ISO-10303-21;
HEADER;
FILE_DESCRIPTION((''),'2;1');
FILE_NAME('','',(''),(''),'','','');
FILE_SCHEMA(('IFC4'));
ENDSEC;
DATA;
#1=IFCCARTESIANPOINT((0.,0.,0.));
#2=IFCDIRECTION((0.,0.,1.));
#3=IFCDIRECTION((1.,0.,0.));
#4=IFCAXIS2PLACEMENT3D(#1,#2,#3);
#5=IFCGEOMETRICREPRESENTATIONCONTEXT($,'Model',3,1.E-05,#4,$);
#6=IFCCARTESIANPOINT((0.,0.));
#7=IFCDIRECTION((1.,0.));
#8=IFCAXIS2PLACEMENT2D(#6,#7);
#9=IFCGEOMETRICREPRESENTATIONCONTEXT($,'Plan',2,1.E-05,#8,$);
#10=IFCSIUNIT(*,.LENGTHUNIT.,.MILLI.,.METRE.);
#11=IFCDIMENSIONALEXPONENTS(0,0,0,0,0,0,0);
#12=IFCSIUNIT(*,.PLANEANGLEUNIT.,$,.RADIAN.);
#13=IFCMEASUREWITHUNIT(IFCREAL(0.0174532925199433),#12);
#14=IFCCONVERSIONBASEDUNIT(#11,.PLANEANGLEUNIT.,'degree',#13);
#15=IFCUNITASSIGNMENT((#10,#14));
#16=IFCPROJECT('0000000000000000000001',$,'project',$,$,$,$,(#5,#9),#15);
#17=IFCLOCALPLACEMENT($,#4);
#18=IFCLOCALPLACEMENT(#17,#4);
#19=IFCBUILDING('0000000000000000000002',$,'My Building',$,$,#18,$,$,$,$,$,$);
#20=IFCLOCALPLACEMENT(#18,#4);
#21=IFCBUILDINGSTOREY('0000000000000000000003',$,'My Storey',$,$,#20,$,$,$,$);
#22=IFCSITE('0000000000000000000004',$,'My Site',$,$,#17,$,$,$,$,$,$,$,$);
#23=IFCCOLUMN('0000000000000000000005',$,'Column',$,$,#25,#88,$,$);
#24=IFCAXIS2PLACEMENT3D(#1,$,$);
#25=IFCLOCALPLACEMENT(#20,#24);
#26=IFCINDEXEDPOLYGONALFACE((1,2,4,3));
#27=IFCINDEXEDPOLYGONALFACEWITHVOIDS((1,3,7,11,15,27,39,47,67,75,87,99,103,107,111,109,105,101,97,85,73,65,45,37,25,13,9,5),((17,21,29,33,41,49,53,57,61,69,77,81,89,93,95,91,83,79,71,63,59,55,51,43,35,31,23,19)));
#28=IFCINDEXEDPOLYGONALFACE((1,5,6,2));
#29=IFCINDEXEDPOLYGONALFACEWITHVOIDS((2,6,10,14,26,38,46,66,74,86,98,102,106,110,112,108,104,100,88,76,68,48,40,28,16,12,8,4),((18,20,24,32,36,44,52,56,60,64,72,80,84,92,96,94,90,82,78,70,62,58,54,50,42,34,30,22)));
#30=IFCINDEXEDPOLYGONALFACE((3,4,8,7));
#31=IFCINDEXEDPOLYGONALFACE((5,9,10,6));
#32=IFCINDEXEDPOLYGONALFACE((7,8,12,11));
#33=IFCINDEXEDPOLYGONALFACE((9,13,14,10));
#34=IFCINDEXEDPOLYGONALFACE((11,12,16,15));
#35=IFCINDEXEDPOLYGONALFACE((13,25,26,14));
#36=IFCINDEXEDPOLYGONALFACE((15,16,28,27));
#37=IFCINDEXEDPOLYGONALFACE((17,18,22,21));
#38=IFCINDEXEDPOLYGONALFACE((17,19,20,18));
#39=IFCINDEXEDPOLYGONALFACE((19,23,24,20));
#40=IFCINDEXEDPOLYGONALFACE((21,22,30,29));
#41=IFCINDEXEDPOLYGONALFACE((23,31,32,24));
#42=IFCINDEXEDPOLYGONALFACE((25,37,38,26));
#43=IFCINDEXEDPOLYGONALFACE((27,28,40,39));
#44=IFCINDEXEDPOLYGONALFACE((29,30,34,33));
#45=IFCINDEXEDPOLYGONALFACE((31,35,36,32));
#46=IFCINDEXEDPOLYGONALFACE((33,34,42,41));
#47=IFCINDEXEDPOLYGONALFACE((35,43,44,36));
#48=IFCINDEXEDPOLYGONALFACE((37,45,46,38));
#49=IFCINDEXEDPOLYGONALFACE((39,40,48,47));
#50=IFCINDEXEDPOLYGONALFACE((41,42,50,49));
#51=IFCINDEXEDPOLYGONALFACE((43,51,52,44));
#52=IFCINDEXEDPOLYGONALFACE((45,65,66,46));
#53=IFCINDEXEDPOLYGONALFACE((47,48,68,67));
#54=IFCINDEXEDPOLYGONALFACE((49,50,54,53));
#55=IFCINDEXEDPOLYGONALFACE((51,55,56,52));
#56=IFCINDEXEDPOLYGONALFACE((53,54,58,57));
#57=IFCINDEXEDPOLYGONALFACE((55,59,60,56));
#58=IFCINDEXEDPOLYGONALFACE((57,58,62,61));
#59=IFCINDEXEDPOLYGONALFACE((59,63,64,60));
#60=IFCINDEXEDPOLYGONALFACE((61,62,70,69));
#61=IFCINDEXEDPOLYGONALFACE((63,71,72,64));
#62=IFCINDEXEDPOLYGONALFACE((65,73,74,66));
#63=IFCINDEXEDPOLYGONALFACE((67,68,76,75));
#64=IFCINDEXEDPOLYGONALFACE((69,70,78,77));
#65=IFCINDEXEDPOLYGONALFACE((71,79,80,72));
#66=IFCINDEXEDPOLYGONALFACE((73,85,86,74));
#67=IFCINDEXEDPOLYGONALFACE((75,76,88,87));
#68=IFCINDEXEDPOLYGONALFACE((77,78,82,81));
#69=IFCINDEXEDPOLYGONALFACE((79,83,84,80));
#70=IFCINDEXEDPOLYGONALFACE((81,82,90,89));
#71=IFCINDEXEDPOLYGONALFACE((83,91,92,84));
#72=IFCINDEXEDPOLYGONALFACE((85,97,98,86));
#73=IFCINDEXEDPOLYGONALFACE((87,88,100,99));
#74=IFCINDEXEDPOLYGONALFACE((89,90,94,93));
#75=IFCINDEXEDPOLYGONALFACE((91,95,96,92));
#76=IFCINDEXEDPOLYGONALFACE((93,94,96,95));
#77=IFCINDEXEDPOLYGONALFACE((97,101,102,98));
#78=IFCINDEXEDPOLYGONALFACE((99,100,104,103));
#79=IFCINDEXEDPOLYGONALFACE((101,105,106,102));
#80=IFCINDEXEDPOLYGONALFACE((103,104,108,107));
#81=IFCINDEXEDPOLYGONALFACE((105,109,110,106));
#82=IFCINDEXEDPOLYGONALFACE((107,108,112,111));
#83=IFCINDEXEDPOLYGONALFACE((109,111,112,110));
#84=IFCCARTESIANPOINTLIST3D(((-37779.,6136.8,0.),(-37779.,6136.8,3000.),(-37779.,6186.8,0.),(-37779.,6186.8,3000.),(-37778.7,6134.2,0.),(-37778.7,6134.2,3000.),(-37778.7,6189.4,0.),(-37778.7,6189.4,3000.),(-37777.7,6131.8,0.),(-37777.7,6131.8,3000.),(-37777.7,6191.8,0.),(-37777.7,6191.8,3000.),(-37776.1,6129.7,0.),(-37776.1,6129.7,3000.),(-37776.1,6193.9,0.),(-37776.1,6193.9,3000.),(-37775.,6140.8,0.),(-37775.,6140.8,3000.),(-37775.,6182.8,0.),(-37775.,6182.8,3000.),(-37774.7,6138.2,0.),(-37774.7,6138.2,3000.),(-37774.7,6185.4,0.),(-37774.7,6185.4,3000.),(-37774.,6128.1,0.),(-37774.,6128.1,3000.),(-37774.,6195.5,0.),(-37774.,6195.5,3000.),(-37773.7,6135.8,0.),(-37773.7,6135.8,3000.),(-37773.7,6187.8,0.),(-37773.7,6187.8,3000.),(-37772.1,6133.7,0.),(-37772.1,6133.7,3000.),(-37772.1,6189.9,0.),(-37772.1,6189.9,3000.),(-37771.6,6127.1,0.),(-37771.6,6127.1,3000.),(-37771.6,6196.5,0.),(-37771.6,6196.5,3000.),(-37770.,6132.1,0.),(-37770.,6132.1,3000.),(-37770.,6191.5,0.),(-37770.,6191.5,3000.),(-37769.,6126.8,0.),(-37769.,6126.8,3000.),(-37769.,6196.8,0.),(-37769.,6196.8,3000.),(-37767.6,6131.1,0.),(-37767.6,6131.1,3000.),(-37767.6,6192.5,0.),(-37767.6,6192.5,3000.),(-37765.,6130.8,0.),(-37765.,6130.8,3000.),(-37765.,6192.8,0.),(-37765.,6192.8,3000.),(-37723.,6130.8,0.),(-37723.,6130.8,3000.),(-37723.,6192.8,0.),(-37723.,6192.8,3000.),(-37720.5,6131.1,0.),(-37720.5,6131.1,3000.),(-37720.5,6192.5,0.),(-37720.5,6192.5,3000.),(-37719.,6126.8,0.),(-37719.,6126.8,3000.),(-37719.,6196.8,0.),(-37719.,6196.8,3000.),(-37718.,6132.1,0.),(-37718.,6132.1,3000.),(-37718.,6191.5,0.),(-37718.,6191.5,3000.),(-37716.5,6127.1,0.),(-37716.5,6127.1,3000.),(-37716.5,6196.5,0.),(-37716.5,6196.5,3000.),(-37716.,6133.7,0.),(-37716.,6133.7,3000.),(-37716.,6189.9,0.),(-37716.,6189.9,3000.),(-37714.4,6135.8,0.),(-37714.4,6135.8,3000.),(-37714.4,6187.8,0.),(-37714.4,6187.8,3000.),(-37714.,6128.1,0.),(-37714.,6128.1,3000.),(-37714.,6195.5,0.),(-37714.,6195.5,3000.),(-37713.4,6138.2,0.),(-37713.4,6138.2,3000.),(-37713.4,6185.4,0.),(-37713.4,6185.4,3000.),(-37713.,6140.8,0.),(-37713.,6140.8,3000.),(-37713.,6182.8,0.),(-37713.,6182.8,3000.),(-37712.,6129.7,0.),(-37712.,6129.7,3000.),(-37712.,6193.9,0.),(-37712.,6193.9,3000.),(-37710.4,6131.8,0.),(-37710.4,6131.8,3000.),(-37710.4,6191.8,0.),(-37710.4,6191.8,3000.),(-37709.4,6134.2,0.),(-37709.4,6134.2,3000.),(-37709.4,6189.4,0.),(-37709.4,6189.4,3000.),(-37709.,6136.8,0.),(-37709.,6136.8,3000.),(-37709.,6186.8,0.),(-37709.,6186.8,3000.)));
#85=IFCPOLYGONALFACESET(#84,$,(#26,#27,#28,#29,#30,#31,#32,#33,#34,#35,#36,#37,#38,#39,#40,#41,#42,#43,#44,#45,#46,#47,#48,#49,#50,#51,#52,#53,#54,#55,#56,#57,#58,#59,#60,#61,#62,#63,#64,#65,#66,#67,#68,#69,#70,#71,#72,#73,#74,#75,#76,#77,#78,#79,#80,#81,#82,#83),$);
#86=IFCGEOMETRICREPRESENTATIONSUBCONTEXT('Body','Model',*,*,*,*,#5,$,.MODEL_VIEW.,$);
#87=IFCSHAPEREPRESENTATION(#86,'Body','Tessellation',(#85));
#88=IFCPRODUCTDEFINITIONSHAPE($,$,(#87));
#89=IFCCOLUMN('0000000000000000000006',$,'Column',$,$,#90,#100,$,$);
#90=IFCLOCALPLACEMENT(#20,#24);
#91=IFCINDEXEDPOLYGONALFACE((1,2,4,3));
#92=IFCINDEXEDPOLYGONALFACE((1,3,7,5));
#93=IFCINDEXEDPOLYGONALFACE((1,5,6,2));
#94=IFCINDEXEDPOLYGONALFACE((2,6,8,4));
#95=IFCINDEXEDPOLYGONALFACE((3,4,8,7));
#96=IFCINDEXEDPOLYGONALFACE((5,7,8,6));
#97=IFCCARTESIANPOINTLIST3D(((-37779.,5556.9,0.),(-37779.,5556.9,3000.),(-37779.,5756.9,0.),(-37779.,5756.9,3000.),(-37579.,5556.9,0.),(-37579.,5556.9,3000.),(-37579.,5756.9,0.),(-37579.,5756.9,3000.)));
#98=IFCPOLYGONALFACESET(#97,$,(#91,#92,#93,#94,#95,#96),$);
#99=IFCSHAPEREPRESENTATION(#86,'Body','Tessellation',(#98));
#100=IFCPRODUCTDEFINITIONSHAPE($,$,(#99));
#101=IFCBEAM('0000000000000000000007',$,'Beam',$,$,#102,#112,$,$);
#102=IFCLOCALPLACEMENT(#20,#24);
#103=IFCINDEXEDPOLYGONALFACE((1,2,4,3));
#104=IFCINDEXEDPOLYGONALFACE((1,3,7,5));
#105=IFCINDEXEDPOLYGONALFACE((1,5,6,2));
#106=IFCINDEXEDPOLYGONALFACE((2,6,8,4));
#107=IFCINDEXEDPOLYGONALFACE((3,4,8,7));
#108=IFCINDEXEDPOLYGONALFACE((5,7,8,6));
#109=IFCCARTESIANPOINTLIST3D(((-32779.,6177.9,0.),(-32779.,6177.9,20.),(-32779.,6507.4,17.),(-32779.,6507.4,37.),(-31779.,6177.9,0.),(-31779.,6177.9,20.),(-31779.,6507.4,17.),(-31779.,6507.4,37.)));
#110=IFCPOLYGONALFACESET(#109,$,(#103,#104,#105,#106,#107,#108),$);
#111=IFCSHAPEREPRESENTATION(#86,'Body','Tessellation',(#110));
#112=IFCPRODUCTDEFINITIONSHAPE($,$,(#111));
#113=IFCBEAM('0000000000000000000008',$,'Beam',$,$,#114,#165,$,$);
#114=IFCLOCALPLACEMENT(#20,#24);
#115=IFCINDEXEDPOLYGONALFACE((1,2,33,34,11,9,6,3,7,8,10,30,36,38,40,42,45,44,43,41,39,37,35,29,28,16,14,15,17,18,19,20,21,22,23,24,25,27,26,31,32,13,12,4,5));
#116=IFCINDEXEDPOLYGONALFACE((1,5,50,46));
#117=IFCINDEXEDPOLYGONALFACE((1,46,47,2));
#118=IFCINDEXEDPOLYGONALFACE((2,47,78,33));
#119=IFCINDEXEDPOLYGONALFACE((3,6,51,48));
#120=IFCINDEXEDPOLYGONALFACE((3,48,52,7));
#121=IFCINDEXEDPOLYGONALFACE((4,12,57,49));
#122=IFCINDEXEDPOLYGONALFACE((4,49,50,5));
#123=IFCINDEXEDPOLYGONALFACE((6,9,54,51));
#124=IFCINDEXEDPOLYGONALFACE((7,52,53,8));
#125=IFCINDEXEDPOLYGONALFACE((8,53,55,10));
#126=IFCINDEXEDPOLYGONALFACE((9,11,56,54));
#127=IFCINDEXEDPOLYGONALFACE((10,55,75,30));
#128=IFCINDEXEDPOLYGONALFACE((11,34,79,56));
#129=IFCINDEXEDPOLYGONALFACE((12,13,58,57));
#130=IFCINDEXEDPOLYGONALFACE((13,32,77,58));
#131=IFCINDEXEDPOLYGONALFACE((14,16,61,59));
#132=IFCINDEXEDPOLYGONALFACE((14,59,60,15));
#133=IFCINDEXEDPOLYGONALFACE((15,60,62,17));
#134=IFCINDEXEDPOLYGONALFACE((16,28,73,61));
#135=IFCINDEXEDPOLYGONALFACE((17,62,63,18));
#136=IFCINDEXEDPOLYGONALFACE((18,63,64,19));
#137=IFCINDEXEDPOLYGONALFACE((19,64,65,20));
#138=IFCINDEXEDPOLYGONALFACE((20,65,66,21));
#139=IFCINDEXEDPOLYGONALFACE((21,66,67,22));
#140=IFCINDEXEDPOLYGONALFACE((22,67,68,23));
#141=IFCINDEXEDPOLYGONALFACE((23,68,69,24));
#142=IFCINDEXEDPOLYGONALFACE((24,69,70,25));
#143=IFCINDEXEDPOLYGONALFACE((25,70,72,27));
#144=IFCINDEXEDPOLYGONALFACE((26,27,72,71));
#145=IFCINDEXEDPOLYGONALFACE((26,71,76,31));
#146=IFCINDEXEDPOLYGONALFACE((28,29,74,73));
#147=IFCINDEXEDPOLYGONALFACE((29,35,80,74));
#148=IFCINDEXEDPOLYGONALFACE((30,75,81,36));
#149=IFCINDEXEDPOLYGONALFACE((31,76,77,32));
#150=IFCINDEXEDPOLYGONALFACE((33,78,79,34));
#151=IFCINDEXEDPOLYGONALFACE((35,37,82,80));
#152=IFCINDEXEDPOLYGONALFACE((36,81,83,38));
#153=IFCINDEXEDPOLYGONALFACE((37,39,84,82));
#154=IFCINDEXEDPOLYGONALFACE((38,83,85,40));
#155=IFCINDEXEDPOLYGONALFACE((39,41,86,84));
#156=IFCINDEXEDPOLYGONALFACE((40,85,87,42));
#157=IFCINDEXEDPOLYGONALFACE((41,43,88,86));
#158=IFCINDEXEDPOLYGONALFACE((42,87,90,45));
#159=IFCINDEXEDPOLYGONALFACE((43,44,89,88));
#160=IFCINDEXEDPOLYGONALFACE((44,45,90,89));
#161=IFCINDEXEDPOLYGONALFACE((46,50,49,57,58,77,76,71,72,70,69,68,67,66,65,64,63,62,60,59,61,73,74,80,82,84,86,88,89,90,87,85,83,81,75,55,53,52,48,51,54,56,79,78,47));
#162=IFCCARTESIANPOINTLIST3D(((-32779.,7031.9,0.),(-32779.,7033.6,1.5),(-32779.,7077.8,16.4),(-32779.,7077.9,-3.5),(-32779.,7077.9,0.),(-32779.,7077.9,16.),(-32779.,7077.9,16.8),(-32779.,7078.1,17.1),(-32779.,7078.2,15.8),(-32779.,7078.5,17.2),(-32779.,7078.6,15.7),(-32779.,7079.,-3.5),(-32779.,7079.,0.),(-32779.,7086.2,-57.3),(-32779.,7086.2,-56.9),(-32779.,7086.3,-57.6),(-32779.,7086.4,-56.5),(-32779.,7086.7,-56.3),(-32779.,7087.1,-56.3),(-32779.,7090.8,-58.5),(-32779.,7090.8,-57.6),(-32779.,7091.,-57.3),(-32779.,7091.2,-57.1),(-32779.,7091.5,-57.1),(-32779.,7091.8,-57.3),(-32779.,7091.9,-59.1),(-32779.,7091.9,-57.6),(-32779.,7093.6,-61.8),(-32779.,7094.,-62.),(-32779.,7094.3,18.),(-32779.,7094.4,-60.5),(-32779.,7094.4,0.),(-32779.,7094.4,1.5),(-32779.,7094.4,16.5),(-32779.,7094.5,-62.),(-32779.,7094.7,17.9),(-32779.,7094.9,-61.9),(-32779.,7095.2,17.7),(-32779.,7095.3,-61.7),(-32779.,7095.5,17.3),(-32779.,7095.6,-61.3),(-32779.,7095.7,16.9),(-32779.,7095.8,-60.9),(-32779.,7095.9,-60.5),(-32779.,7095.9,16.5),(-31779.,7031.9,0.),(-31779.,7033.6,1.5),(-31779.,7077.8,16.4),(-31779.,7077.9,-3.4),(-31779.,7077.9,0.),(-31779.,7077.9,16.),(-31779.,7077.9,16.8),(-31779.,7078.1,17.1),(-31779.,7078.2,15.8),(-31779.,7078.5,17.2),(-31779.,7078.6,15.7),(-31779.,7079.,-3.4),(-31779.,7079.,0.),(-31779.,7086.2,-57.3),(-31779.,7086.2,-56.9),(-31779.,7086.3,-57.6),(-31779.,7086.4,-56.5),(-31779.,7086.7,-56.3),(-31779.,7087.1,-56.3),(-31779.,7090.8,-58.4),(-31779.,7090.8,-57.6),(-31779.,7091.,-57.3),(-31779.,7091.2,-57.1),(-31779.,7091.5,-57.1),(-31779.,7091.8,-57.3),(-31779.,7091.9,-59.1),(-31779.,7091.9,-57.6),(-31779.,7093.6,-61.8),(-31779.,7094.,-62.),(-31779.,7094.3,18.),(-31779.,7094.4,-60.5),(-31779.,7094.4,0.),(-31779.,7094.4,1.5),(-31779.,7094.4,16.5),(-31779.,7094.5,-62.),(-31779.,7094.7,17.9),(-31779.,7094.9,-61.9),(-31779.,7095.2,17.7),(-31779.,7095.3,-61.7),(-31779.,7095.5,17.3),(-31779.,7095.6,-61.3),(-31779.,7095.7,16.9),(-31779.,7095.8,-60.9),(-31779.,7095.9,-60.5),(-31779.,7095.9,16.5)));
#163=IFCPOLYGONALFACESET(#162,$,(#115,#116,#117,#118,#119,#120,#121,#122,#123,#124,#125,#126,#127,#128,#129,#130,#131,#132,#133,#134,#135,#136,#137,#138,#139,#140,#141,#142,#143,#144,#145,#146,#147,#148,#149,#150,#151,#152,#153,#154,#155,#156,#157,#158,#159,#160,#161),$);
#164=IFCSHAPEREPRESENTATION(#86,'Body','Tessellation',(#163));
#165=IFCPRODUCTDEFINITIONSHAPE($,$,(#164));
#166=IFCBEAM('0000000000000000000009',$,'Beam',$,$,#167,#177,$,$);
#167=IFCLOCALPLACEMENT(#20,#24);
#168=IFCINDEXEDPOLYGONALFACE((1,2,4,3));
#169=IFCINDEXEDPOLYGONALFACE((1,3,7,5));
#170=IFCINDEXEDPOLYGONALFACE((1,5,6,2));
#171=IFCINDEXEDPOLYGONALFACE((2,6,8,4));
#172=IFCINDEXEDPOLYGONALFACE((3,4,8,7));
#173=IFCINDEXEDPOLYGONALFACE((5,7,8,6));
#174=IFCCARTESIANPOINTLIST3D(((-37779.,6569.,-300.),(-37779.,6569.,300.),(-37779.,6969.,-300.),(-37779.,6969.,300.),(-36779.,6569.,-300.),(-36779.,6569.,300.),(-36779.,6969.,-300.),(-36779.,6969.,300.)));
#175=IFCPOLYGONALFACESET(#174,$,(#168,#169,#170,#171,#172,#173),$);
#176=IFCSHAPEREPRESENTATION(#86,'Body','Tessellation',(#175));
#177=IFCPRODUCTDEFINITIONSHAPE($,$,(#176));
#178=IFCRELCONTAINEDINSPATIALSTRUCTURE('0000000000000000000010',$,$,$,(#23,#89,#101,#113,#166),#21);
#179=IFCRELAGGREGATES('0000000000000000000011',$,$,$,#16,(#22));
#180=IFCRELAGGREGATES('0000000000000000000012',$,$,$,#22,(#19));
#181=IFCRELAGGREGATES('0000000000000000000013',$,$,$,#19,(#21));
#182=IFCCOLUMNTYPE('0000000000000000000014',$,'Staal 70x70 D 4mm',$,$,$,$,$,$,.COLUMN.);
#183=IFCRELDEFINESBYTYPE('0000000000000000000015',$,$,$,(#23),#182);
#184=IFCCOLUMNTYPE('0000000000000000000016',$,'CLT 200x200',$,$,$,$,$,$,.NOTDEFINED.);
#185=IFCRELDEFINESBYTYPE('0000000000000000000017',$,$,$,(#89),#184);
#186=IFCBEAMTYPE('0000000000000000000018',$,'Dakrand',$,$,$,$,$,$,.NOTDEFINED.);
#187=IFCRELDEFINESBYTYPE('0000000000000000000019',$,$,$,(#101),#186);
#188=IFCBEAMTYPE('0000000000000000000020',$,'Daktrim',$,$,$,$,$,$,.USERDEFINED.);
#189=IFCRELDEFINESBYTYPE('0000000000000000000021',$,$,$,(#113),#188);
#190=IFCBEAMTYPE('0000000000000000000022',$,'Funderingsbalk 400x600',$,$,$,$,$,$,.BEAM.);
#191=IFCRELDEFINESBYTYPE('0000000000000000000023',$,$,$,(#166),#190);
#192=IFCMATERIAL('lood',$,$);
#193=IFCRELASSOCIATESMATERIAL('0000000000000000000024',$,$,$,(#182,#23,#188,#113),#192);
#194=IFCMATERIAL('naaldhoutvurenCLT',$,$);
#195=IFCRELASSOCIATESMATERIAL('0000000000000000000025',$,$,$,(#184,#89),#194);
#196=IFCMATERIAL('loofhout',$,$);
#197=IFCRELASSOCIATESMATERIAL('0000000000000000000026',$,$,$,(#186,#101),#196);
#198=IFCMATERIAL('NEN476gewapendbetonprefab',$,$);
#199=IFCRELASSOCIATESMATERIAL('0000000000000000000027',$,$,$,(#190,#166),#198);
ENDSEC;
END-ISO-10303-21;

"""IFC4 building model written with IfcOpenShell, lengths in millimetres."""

from ifc_helpers import new_model, entity, si_unit, converted_unit, frame, origin_with_axes, origin_2d_with_axis, place, context, subcontext, project, spatial, line, arc, indexed_curve, rectangle, hollow_rectangle, outline, extrude, material, material_profile, profile_set, profile_usage, type_object, element, save


model = new_model("IFC4")

# Units and contexts
model_context = context("Model", 3, precision=1e-05, world=origin_with_axes())
plan_context = context("Plan", 2, precision=1e-05, world=origin_2d_with_axis())
body_context = subcontext(model_context, "Body", "Model", "MODEL_VIEW")
ifc_project = project(units=[si_unit("LENGTHUNIT", "METRE", prefix="MILLI"), converted_unit("PLANEANGLEUNIT", "degree", entity("IfcReal", 0.0174532925199433), si_unit("PLANEANGLEUNIT", "RADIAN"), dimensions=[0, 0, 0, 0, 0, 0, 0])], contexts=[model_context, plan_context])

# Site, building, storey
site_placement = place(None, origin_with_axes())
site = spatial("IfcSite", under=ifc_project, at=site_placement, Name="My Site")
building_placement = place(site_placement, origin_with_axes())
building = spatial("IfcBuilding", under=site, at=building_placement, Name="My Building")
storey_placement = place(building_placement, origin_with_axes())
storey = spatial("IfcBuildingStorey", under=building, at=storey_placement, Name="My Storey")

# Columns
ifc_material_1 = material(Name="lood")
ifc_material_profile_1 = material_profile(ifc_material_1, hollow_rectangle(XDim=70.0, YDim=70.0, WallThickness=4.0, InnerFilletRadius=10.0, OuterFilletRadius=10.0))
ifc_profile_set_1 = profile_set([ifc_material_profile_1], Name="lood")
ifc_profile_usage_1 = profile_usage(ifc_profile_set_1, cardinal=5)
column_type_1 = type_object("IfcColumnType", Name="Staal 70x70 D 4mm", PredefinedType="COLUMN", material=ifc_profile_set_1)
column_1_placement = place(storey_placement, frame((-37744.0, 6161.8, 0.0), z_axis=(0.0, 0.0, 1.0), x_axis=(1.0, 0.0, 0.0)))
element("IfcColumn", 1, at=column_1_placement, inside=storey, type_object=column_type_1, material=ifc_profile_usage_1, Name="Column", context=body_context, shape_type="SweptSolid", body=[
    extrude(hollow_rectangle(XDim=70.0, YDim=70.0, WallThickness=4.0, InnerFilletRadius=10.0, OuterFilletRadius=10.0), origin_with_axes(), (0.0, 0.0, 1.0), 3000.0),
])
ifc_material_2 = material(Name="naaldhoutvurenCLT")
ifc_material_profile_2 = material_profile(ifc_material_2, rectangle(XDim=200.0, YDim=200.0))
ifc_profile_set_2 = profile_set([ifc_material_profile_2], Name="naaldhoutvurenCLT")
ifc_profile_usage_2 = profile_usage(ifc_profile_set_2, cardinal=5)
column_type_2 = type_object("IfcColumnType", Name="CLT 200x200", PredefinedType="NOTDEFINED", material=ifc_profile_set_2)
column_2_placement = place(storey_placement, frame((-37679.0, 5656.9, 0.0), z_axis=(0.0, 0.0, 1.0), x_axis=(1.0, 0.0, 0.0)))
element("IfcColumn", 2, at=column_2_placement, inside=storey, type_object=column_type_2, material=ifc_profile_usage_2, Name="Column", context=body_context, shape_type="SweptSolid", body=[
    extrude(rectangle(XDim=200.0, YDim=200.0), origin_with_axes(), (0.0, 0.0, 1.0), 3000.0),
])

# Beams
ifc_material_3 = material(Name="loofhout")
ifc_material_profile_3 = material_profile(ifc_material_3, outline(indexed_curve([(329.6, 37.0), (329.6, 17.0), (0.0, 0.0), (0.0, 20.0)], segments=[line(3, 2), line(2, 1), line(1, 4), line(4, 3)], self_intersect=False)))
ifc_profile_set_3 = profile_set([ifc_material_profile_3], Name="loofhout")
ifc_profile_usage_3 = profile_usage(ifc_profile_set_3)
beam_type_1 = type_object("IfcBeamType", Name="Dakrand", PredefinedType="NOTDEFINED", material=ifc_profile_set_3)
beam_1_placement = place(storey_placement, frame((-32779.0, 6177.9, 0.0), z_axis=(1.0, 0.0, 0.0), x_axis=(0.0, 1.0, 0.0)))
element("IfcBeam", 3, at=beam_1_placement, inside=storey, type_object=beam_type_1, material=ifc_profile_usage_3, Name="Beam", context=body_context, shape_type="SweptSolid", body=[
    extrude(outline(indexed_curve([(329.6, 37.0), (329.6, 17.0), (0.0, 0.0), (0.0, 20.0)], segments=[line(3, 2), line(2, 1), line(1, 4), line(4, 3)], self_intersect=False)), origin_with_axes(), (0.0, 0.0, 1.0), 1000.0),
])
ifc_material_profile_4 = material_profile(ifc_material_1, outline(indexed_curve([(12.9, -58.5), (12.9, -57.6), (13.5, -57.1), (14.1, -57.6), (14.1, -59.1), (16.5, -60.5), (16.5, 0.0), (1.1, 0.0), (1.1, -3.5), (0.0, -3.5), (0.0, 0.0), (-46.0, 0.0), (-44.3, 1.5), (16.5, 1.5), (16.5, 16.5), (0.7, 15.7), (-0.1, 16.4), (0.6, 17.2), (16.4, 18.0), (17.6, 17.3), (18.0, 16.5), (18.0, -60.5), (17.2, -61.8), (15.8, -61.8), (8.5, -57.6), (8.4, -56.7), (9.2, -56.3)], segments=[line(10, 9), line(9, 8), line(8, 7), line(7, 6), line(6, 5), line(5, 4), arc(4, 3, 2), line(2, 1), line(1, 27), arc(27, 26, 25), line(25, 24), arc(24, 23, 22), line(22, 21), arc(21, 20, 19), line(19, 18), arc(18, 17, 16), line(16, 15), line(15, 14), line(14, 13), line(13, 12), line(12, 11), line(11, 10)], self_intersect=False)))
ifc_profile_set_4 = profile_set([ifc_material_profile_4], Name="lood")
ifc_profile_usage_4 = profile_usage(ifc_profile_set_4, cardinal=5)
beam_type_2 = type_object("IfcBeamType", Name="Daktrim", PredefinedType="USERDEFINED", material=ifc_profile_set_4)
beam_2_placement = place(storey_placement, frame((-32779.0, 7077.9, 0.0), z_axis=(1.0, 0.0, 0.0), x_axis=(0.0, 1.0, 0.0)))
element("IfcBeam", 4, at=beam_2_placement, inside=storey, type_object=beam_type_2, material=ifc_profile_usage_4, Name="Beam", context=body_context, shape_type="SweptSolid", body=[
    extrude(outline(indexed_curve([(12.9, -58.5), (12.9, -57.6), (13.5, -57.1), (14.1, -57.6), (14.1, -59.1), (16.5, -60.5), (16.5, 0.0), (1.1, 0.0), (1.1, -3.5), (0.0, -3.5), (0.0, 0.0), (-46.0, 0.0), (-44.3, 1.5), (16.5, 1.5), (16.5, 16.5), (0.7, 15.7), (-0.1, 16.4), (0.6, 17.2), (16.4, 18.0), (17.6, 17.3), (18.0, 16.5), (18.0, -60.5), (17.2, -61.8), (15.8, -61.8), (8.5, -57.6), (8.4, -56.7), (9.2, -56.3)], segments=[line(10, 9), line(9, 8), line(8, 7), line(7, 6), line(6, 5), line(5, 4), arc(4, 3, 2), line(2, 1), line(1, 27), arc(27, 26, 25), line(25, 24), arc(24, 23, 22), line(22, 21), arc(21, 20, 19), line(19, 18), arc(18, 17, 16), line(16, 15), line(15, 14), line(14, 13), line(13, 12), line(12, 11), line(11, 10)], self_intersect=False)), origin_with_axes(), (0.0, 0.0, 1.0), 1000.0),
])
ifc_material_4 = material(Name="NEN476gewapendbetonprefab")
ifc_material_profile_5 = material_profile(ifc_material_4, rectangle(XDim=400.0, YDim=600.0))
ifc_profile_set_5 = profile_set([ifc_material_profile_5], Name="gewapendbetonprefab")
ifc_profile_usage_5 = profile_usage(ifc_profile_set_5, cardinal=5)
beam_type_3 = type_object("IfcBeamType", Name="Funderingsbalk 400x600", PredefinedType="BEAM", material=ifc_profile_set_5)
beam_3_placement = place(storey_placement, frame((-37779.0, 6769.0, 0.0), z_axis=(1.0, 0.0, 0.0), x_axis=(0.0, 1.0, 0.0)))
element("IfcBeam", 5, at=beam_3_placement, inside=storey, type_object=beam_type_3, material=ifc_profile_usage_5, Name="Beam", context=body_context, shape_type="SweptSolid", body=[
    extrude(rectangle(XDim=400.0, YDim=600.0), origin_with_axes(), (0.0, 0.0, 1.0), 1000.0),
])

save(model, "model.ifc")
